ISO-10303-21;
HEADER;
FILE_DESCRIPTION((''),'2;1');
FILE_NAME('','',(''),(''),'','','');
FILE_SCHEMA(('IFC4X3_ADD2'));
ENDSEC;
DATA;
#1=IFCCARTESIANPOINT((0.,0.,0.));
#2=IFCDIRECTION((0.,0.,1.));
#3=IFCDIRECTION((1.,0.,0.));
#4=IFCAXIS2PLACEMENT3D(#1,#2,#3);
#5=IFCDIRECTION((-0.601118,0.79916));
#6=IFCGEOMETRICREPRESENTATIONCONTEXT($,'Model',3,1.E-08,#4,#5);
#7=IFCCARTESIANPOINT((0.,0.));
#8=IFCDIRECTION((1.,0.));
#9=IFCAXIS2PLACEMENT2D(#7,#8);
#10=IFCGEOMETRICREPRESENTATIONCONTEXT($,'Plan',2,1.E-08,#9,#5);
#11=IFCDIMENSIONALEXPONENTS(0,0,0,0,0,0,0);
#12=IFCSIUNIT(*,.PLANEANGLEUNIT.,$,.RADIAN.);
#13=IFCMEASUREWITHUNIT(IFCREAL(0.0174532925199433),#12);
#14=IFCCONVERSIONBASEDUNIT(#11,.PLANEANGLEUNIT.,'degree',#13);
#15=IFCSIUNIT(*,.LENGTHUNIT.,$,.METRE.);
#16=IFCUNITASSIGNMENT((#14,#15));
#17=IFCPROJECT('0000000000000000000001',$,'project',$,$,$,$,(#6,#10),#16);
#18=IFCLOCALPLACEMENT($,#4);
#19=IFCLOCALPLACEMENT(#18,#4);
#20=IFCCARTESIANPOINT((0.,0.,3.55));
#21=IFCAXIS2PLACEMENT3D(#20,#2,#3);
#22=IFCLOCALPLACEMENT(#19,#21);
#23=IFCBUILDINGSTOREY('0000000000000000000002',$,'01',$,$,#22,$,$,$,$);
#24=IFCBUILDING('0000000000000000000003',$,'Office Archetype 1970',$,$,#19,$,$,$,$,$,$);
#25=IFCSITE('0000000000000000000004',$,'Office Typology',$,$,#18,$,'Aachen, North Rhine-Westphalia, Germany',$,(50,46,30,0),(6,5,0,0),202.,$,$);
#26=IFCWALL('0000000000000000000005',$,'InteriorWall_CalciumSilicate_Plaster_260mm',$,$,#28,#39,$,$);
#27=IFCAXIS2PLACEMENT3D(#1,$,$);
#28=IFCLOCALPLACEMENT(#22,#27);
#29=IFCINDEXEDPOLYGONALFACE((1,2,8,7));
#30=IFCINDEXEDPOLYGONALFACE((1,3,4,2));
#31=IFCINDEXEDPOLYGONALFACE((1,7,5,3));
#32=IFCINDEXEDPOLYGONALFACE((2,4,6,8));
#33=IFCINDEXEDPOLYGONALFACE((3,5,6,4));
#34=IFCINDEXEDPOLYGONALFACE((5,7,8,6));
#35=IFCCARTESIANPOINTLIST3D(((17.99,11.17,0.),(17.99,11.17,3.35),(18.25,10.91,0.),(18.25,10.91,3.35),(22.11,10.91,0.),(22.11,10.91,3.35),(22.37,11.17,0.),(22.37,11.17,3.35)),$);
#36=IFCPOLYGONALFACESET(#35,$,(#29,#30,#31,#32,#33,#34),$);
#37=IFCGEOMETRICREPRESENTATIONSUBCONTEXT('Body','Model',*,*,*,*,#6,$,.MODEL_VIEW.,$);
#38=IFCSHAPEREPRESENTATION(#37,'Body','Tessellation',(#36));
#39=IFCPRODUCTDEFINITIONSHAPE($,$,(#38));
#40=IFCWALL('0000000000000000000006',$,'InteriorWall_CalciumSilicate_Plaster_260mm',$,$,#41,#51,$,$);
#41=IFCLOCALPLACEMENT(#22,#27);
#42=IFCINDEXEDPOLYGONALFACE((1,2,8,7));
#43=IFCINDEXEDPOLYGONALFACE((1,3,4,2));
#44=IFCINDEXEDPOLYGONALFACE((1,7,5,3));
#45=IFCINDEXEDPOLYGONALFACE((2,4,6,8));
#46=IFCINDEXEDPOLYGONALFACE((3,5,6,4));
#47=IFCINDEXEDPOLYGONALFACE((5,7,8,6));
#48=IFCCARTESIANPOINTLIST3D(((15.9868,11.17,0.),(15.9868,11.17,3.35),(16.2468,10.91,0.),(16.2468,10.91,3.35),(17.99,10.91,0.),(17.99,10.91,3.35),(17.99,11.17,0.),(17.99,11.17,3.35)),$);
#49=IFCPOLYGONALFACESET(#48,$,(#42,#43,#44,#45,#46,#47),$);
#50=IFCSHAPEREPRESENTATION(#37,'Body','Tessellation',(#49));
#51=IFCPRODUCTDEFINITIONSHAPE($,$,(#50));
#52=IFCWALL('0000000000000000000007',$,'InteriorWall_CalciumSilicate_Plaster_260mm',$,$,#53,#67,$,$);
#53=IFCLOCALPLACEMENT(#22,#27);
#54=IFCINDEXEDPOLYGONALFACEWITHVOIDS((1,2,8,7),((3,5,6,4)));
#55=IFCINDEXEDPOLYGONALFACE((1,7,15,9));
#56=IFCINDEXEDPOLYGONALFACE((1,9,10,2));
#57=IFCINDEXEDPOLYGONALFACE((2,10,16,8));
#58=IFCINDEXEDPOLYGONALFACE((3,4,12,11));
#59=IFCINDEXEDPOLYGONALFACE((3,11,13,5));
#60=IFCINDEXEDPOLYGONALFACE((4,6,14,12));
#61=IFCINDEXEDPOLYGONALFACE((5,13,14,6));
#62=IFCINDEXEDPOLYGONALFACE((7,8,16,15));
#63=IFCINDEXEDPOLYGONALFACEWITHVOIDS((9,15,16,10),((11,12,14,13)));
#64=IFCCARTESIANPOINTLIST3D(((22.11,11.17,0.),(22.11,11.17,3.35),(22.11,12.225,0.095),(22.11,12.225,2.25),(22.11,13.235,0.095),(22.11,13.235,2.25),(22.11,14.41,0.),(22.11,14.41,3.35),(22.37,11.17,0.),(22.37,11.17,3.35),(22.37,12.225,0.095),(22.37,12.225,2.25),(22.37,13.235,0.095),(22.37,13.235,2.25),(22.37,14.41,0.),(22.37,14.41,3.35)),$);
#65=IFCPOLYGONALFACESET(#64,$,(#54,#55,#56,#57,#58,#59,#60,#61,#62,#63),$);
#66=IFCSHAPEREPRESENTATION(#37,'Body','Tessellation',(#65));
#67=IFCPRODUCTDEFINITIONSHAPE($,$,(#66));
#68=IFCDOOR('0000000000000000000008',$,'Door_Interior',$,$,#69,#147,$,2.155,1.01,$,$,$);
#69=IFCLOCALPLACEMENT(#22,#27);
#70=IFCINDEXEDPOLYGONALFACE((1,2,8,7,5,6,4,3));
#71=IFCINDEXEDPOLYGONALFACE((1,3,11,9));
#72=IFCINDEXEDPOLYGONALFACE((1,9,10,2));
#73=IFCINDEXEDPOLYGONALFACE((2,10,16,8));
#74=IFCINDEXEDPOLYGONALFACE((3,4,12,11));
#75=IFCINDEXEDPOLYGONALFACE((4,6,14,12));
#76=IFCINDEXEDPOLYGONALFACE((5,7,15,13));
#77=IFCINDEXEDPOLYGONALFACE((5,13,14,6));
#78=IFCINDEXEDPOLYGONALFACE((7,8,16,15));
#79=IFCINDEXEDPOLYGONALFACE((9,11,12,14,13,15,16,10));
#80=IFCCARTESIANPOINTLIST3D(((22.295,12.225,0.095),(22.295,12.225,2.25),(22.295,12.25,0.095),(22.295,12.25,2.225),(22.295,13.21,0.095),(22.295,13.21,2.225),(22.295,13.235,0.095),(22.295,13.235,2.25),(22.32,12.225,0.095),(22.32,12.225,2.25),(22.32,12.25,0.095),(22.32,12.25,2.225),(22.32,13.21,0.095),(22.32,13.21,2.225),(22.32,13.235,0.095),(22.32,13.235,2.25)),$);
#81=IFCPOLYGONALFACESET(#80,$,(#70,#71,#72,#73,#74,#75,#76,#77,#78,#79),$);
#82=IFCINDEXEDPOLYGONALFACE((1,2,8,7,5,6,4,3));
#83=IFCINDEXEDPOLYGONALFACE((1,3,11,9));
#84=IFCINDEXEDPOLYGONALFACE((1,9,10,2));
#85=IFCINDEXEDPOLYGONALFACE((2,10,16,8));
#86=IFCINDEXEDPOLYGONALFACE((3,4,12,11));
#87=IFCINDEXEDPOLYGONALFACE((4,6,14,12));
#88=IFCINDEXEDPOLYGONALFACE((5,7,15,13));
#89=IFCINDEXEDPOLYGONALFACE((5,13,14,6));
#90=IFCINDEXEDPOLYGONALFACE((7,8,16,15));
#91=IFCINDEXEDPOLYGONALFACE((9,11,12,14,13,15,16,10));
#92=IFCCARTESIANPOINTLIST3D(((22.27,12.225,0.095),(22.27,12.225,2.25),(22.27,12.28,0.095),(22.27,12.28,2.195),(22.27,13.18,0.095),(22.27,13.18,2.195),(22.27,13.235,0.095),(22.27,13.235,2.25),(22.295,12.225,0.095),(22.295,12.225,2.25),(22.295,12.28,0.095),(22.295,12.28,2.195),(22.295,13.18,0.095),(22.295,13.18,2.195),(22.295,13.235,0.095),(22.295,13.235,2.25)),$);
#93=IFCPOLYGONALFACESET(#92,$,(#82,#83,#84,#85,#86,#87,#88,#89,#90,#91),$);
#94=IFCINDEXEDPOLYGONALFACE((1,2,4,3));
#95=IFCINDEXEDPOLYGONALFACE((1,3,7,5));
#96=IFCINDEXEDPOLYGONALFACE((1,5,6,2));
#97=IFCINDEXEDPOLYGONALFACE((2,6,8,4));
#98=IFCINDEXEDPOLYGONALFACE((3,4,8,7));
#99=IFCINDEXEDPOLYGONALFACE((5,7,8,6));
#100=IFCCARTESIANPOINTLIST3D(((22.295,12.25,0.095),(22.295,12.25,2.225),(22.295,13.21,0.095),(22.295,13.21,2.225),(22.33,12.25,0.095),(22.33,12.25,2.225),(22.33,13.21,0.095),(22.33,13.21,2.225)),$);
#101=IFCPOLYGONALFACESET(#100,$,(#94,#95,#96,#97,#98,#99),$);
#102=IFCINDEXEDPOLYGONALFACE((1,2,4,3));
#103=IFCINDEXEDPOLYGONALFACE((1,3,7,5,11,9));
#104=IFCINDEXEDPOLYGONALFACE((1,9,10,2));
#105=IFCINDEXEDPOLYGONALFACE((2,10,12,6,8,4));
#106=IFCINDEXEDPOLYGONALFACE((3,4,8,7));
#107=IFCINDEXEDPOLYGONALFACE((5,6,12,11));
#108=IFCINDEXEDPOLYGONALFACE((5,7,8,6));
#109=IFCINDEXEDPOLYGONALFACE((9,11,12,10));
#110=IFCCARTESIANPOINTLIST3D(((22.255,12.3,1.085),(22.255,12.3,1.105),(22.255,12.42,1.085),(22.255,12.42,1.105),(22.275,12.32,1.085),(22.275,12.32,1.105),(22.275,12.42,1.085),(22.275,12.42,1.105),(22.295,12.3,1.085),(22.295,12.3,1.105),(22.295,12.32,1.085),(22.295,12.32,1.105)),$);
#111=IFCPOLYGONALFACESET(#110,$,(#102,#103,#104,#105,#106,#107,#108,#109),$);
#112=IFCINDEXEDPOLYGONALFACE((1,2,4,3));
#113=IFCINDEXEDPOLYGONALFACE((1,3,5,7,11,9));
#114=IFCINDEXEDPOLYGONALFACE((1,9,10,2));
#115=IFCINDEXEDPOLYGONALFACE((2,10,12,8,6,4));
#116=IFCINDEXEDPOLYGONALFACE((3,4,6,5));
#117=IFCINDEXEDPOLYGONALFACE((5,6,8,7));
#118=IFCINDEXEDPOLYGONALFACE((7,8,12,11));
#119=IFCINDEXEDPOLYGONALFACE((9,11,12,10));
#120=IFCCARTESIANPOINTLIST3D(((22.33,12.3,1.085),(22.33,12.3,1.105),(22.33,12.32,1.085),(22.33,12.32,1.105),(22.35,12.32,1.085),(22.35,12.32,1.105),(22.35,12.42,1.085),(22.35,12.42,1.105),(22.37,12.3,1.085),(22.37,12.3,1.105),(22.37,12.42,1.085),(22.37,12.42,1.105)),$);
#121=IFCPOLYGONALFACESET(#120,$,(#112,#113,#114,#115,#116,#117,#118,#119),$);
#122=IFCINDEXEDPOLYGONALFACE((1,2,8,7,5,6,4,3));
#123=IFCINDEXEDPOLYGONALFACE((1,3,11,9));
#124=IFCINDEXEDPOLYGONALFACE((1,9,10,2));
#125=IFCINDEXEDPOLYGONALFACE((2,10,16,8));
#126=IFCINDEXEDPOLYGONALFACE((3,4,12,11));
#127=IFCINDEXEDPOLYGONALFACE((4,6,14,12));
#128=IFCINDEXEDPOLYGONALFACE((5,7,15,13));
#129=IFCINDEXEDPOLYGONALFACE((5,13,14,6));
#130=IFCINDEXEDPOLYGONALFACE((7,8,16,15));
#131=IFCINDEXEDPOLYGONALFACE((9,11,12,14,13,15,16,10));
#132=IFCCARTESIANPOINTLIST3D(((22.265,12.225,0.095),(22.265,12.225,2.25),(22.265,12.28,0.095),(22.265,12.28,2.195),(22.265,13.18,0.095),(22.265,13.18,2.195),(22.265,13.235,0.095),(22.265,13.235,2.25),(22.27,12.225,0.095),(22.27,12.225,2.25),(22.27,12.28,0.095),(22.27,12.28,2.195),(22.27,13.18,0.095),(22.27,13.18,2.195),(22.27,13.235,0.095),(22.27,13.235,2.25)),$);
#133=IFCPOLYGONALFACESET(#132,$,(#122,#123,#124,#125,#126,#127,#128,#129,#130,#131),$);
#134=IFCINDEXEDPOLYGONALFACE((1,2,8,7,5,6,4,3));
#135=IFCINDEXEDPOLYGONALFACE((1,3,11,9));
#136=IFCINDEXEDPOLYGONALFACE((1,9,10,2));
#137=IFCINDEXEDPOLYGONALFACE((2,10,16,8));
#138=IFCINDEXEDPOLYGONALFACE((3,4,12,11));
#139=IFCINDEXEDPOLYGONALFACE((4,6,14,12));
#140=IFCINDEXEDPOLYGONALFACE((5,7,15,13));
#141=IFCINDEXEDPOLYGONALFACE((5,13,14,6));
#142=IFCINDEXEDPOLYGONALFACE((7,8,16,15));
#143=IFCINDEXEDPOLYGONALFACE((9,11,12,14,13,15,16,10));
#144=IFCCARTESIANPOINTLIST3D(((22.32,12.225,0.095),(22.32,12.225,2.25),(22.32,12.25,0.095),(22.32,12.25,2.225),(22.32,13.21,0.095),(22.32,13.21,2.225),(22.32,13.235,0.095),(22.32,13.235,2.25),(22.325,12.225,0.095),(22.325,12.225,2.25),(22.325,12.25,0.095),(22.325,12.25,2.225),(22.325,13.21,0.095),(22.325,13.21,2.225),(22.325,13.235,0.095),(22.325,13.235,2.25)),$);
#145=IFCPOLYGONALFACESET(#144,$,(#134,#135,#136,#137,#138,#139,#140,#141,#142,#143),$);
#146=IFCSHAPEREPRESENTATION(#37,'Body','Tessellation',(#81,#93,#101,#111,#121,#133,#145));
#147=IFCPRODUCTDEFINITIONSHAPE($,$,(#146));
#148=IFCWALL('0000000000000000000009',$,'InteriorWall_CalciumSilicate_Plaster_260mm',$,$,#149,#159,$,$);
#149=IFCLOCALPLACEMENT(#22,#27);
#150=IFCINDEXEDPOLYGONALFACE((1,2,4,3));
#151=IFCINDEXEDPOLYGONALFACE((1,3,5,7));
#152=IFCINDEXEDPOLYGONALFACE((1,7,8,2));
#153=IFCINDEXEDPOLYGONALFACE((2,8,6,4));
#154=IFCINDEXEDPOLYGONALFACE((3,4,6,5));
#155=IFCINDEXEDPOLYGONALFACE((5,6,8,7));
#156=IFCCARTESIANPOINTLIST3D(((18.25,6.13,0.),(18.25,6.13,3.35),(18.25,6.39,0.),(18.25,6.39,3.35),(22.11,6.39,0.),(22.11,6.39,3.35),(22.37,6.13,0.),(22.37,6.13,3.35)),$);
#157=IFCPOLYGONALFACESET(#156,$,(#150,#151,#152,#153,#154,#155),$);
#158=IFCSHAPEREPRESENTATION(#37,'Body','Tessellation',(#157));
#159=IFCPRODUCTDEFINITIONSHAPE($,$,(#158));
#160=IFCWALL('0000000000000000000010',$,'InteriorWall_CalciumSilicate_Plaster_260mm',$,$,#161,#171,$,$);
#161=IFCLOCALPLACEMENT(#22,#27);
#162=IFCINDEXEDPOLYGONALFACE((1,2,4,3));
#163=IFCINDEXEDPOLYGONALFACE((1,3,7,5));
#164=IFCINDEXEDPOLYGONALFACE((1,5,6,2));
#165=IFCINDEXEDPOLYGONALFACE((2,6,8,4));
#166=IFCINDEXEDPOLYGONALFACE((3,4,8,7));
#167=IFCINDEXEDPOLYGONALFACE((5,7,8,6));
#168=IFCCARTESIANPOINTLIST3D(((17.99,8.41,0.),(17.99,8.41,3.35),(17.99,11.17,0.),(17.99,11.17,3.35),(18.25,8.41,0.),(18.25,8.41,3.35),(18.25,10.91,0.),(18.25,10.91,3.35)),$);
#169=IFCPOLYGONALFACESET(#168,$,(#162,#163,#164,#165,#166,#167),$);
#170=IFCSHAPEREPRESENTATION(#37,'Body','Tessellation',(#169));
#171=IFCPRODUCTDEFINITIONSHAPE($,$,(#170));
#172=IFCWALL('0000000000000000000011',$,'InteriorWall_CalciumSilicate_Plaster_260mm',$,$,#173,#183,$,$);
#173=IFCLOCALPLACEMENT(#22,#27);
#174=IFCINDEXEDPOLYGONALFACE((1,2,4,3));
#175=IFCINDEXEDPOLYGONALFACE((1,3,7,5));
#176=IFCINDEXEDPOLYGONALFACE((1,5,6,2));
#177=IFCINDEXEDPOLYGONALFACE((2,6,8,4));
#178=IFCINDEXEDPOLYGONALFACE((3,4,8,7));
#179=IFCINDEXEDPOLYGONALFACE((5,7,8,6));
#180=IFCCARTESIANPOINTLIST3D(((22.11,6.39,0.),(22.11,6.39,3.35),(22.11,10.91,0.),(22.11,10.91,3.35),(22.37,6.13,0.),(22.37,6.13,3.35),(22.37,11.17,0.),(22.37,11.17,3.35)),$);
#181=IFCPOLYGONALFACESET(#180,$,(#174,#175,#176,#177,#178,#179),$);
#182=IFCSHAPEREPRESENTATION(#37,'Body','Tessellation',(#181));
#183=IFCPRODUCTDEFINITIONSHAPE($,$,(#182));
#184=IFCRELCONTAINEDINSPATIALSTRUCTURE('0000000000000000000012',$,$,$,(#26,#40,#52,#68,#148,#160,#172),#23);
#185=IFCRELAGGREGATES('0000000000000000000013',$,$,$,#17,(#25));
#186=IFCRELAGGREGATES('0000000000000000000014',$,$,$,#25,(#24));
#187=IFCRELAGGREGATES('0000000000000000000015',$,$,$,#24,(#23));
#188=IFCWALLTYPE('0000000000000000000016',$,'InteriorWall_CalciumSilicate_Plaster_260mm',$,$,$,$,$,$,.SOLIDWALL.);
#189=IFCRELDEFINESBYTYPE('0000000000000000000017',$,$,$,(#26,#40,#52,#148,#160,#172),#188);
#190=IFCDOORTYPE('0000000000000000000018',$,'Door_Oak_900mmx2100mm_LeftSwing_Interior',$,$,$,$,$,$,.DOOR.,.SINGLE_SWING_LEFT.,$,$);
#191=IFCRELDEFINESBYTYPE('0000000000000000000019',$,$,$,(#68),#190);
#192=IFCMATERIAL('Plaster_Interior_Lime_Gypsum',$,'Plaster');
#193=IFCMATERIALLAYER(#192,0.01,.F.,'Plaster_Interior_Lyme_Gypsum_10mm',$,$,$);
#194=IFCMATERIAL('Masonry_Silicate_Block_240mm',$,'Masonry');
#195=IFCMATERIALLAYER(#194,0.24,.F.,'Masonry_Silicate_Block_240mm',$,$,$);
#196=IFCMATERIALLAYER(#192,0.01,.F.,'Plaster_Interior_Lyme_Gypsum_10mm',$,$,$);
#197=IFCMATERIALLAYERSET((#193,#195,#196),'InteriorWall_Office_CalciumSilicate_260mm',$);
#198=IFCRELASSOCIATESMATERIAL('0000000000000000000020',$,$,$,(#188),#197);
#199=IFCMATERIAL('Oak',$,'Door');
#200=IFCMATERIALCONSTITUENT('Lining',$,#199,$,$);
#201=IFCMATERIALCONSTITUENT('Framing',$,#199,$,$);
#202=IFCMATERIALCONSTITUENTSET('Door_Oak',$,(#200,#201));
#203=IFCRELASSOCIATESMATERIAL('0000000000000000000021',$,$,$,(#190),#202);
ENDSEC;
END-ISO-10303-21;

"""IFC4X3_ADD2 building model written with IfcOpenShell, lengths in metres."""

from ifc_helpers import new_model, entity, si_unit, converted_unit, direction, frame, origin_with_axes, origin_2d_with_axis, place, context, subcontext, project, spatial, line, indexed_curve, outline, extrude, source, transform, mapped, material, layer, layer_set, constituent, constituent_set, type_object, type_shapes, element, fill, save


model = new_model("IFC4X3_ADD2")

# Units and contexts
model_context = context("Model", 3, precision=1e-08, world=origin_with_axes(), true_north=direction((-0.601118, 0.79916)))
plan_context = context("Plan", 2, precision=1e-08, world=origin_2d_with_axis(), true_north=direction((-0.601118, 0.79916)))
body_context = subcontext(model_context, "Body", "Model", "MODEL_VIEW")
ifc_project = project(units=[converted_unit("PLANEANGLEUNIT", "degree", entity("IfcReal", 0.0174532925199433), si_unit("PLANEANGLEUNIT", "RADIAN"), dimensions=[0, 0, 0, 0, 0, 0, 0]), si_unit("LENGTHUNIT", "METRE")], contexts=[model_context, plan_context])

# Site, building, storey
site_placement = place(None, origin_with_axes())
site = spatial("IfcSite", under=ifc_project, at=site_placement, Name="Office Typology", LongName="Aachen, North Rhine-Westphalia, Germany", RefLatitude=(50, 46, 30, 0), RefLongitude=(6, 5, 0, 0), RefElevation=202.0)
building_placement = place(site_placement, origin_with_axes())
building = spatial("IfcBuilding", under=site, at=building_placement, Name="Office Archetype 1970")
storey_placement = place(building_placement, frame((0.0, 0.0, 3.55), z_axis=(0.0, 0.0, 1.0), x_axis=(1.0, 0.0, 0.0)))
storey = spatial("IfcBuildingStorey", under=building, at=storey_placement, Name="01")

# Shared definitions
ifc_material_1 = material(Name="Plaster_Interior_Lime_Gypsum", Category="Plaster")
ifc_layer_1 = layer(ifc_material_1, 0.01, ventilated=False, Name="Plaster_Interior_Lyme_Gypsum_10mm")
ifc_material_2 = material(Name="Masonry_Silicate_Block_240mm", Category="Masonry")
ifc_layer_2 = layer(ifc_material_2, 0.24, ventilated=False, Name="Masonry_Silicate_Block_240mm")
ifc_layer_3 = layer(ifc_material_1, 0.01, ventilated=False, Name="Plaster_Interior_Lyme_Gypsum_10mm")
ifc_layer_set_1 = layer_set([ifc_layer_1, ifc_layer_2, ifc_layer_3], Name="InteriorWall_Office_CalciumSilicate_260mm")
wall_type_1 = type_object("IfcWallType", Name="InteriorWall_CalciumSilicate_Plaster_260mm", PredefinedType="SOLIDWALL", material=ifc_layer_set_1)
ifc_material_3 = material(Name="Oak", Category="Door")

# Walls
wall_1_placement = place(storey_placement, frame((22.37, 11.17, 0.0), z_axis=(0.0, 0.0, 1.0), x_axis=(-1.0, 0.0, 0.0)))
element("IfcWall", 1, at=wall_1_placement, inside=storey, type_object=wall_type_1, Name="InteriorWall_CalciumSilicate_Plaster_260mm", context=body_context, shape_type="SweptSolid", body=[
    extrude(outline(indexed_curve([(0.0, 0.0), (0.26, 0.26), (4.12, 0.26), (4.38, 0.0)], segments=[line(1, 2, 3, 4, 1)])), origin_with_axes(), (0.0, 0.0, 1.0), 3.35),
])
wall_2_placement = place(storey_placement, frame((17.99, 11.17, 0.0), z_axis=(0.0, 0.0, 1.0), x_axis=(-1.0, 0.0, 0.0)))
element("IfcWall", 2, at=wall_2_placement, inside=storey, type_object=wall_type_1, Name="InteriorWall_CalciumSilicate_Plaster_260mm", context=body_context, shape_type="SweptSolid", body=[
    extrude(outline(indexed_curve([(0.0, 0.0), (0.0, 0.26), (1.7432, 0.26), (2.0032, 0.0)], segments=[line(1, 2, 3, 4, 1)])), origin_with_axes(), (0.0, 0.0, 1.0), 3.35),
])

# Wall, opening, door
wall_3_placement = place(storey_placement, frame((22.37, 11.17, 0.0), z_axis=(0.0, 0.0, 1.0), x_axis=(0.0, 1.0, 0.0)))
wall_3 = element("IfcWall", 3, at=wall_3_placement, inside=storey, type_object=wall_type_1, Name="InteriorWall_CalciumSilicate_Plaster_260mm", context=body_context, shape_type="SweptSolid", body=[
    extrude(outline(indexed_curve([(0.0, 0.0), (0.0, 0.26), (3.24, 0.26), (3.24, 0.0)], segments=[line(1, 2, 3, 4, 1)])), origin_with_axes(), (0.0, 0.0, 1.0), 3.35),
])
shared_shape_1 = source(origin_with_axes(), body_context, "Body", "SweptSolid", [
    extrude(outline(indexed_curve([(0.0, 0.0), (1.01, 0.0), (1.01, 2.155), (0.0, 2.155), (0.0, 0.0)])), frame((0.0, -0.16, 0.0), z_axis=(0.0, -1.0, 0.0), x_axis=(1.0, 0.0, 0.0)), (0.0, 0.0, -1.0), 0.261),
])
opening_1_placement = place(wall_3_placement, frame((2.065, 0.1, 0.095), z_axis=(0.0, 0.0, 1.0), x_axis=(-1.0, 0.0, 0.0)))
opening_1 = element("IfcOpeningElement", 4, at=opening_1_placement, cuts=wall_3, PredefinedType="OPENING", context=body_context, shape_type="MappedRepresentation", body=[
    mapped(shared_shape_1, transform((0.0, 0.0, 0.0), x_axis=(1.0, 0.0, 0.0), y_axis=(0.0, 1.0, 0.0), z_axis=(0.0, 0.0, 1.0), scale=1.0)),
])
ifc_constituent_1 = constituent(ifc_material_3, Name="Lining")
ifc_constituent_2 = constituent(ifc_material_3, Name="Framing")
ifc_constituent_set_1 = constituent_set(constituents=[ifc_constituent_1, ifc_constituent_2], Name="Door_Oak")
door_type_1 = type_object("IfcDoorType", Name="Door_Oak_900mmx2100mm_LeftSwing_Interior", OperationType="SINGLE_SWING_LEFT", PredefinedType="DOOR", material=ifc_constituent_set_1)
shared_shape_2 = source(origin_with_axes(), body_context, "Body", "SweptSolid", [
    extrude(outline(indexed_curve([(0.0, 0.0), (0.0, 2.155), (1.01, 2.155), (1.01, 0.0), (0.985, 0.0), (0.985, 2.13), (0.025, 2.13), (0.025, 0.0)], segments=[line(1, 2, 3, 4, 5, 6, 7, 8, 1)])), frame((0.0, 0.025, 0.0), z_axis=(0.0, -1.0, 0.0), x_axis=(1.0, 0.0, 0.0)), (0.0, 0.0, -1.0), 0.025),
    extrude(outline(indexed_curve([(0.0, 0.0), (0.0, 2.155), (1.01, 2.155), (1.01, 0.0), (0.955, 0.0), (0.955, 2.1), (0.055, 2.1), (0.055, 0.0)], segments=[line(1, 2, 3, 4, 5, 6, 7, 8, 1)])), frame((0.0, 0.0, 0.0), z_axis=(0.0, -1.0, 0.0), x_axis=(1.0, 0.0, 0.0)), (0.0, 0.0, -1.0), 0.025),
    extrude(outline(indexed_curve([(0.0, 0.0), (0.96, 0.0), (0.96, 0.035), (0.0, 0.035)], segments=[line(1, 2, 3, 4, 1)])), frame((0.025, 0.025, 0.0), z_axis=(0.0, 0.0, 1.0), x_axis=(1.0, 0.0, 0.0)), (0.0, 0.0, 1.0), 2.13),
    extrude(outline(indexed_curve([(0.0, 0.0), (0.0, -0.04), (-0.12, -0.04), (-0.12, -0.02), (-0.02, -0.02), (-0.02, 0.0)], segments=[line(1, 2, 3, 4, 5, 6, 1)])), frame((0.935, 0.025, 0.99), z_axis=(0.0, 0.0, 1.0), x_axis=(1.0, 0.0, 0.0)), (0.0, 0.0, 1.0), 0.02),
    extrude(outline(indexed_curve([(0.0, 0.0), (0.0, 0.04), (-0.12, 0.04), (-0.12, 0.02), (-0.02, 0.02), (-0.02, 0.0)], segments=[line(1, 2, 3, 4, 5, 6, 1)])), frame((0.935, 0.06, 0.99), z_axis=(0.0, 0.0, 1.0), x_axis=(1.0, 0.0, 0.0)), (0.0, 0.0, 1.0), 0.02),
    extrude(outline(indexed_curve([(0.0, 0.0), (0.0, 2.155), (1.01, 2.155), (1.01, 0.0), (0.955, 0.0), (0.955, 2.1), (0.055, 2.1), (0.055, 0.0)], segments=[line(1, 2, 3, 4, 5, 6, 7, 8, 1)])), frame((0.0, -0.005, 0.0), z_axis=(0.0, -1.0, 0.0), x_axis=(1.0, 0.0, 0.0)), (0.0, 0.0, -1.0), 0.005),
    extrude(outline(indexed_curve([(0.0, 0.0), (0.0, 2.155), (1.01, 2.155), (1.01, 0.0), (0.985, 0.0), (0.985, 2.13), (0.025, 2.13), (0.025, 0.0)], segments=[line(1, 2, 3, 4, 5, 6, 7, 8, 1)])), frame((0.0, 0.05, 0.0), z_axis=(0.0, -1.0, 0.0), x_axis=(1.0, 0.0, 0.0)), (0.0, 0.0, -1.0), 0.005),
])
type_shapes(door_type_1, [shared_shape_2])
door_1_placement = place(opening_1_placement, origin_with_axes())
door_1 = element("IfcDoor", 5, at=door_1_placement, inside=storey, type_object=door_type_1, Name="Door_Interior", OverallHeight=2.155, OverallWidth=1.01, context=body_context, shape_type="MappedRepresentation", body=[
    mapped(shared_shape_2, transform((0.0, 0.0, 0.0), x_axis=(1.0, 0.0, 0.0), y_axis=(0.0, 1.0, 0.0), z_axis=(0.0, 0.0, 1.0), scale=1.0)),
])
fill(opening_1, door_1)

# Walls
wall_4_placement = place(storey_placement, frame((18.25, 6.13, 0.0), z_axis=(0.0, 0.0, 1.0), x_axis=(1.0, 0.0, 0.0)))
element("IfcWall", 6, at=wall_4_placement, inside=storey, type_object=wall_type_1, Name="InteriorWall_CalciumSilicate_Plaster_260mm", context=body_context, shape_type="SweptSolid", body=[
    extrude(outline(indexed_curve([(0.0, 0.0), (0.0, 0.26), (3.86, 0.26), (4.12, 0.0)], segments=[line(1, 2, 3, 4, 1)])), origin_with_axes(), (0.0, 0.0, 1.0), 3.35),
])
wall_5_placement = place(storey_placement, frame((17.99, 11.17, 0.0), z_axis=(0.0, 0.0, 1.0), x_axis=(0.0, -1.0, 0.0)))
element("IfcWall", 7, at=wall_5_placement, inside=storey, type_object=wall_type_1, Name="InteriorWall_CalciumSilicate_Plaster_260mm", context=body_context, shape_type="SweptSolid", body=[
    extrude(outline(indexed_curve([(0.0, 0.0), (0.26, 0.26), (2.76, 0.26), (2.76, 0.0)], segments=[line(1, 2, 3, 4, 1)])), origin_with_axes(), (0.0, 0.0, 1.0), 3.35),
])
wall_6_placement = place(storey_placement, frame((22.37, 6.13, 0.0), z_axis=(0.0, 0.0, 1.0), x_axis=(0.0, 1.0, 0.0)))
element("IfcWall", 8, at=wall_6_placement, inside=storey, type_object=wall_type_1, Name="InteriorWall_CalciumSilicate_Plaster_260mm", context=body_context, shape_type="SweptSolid", body=[
    extrude(outline(indexed_curve([(0.0, 0.0), (0.26, 0.26), (4.78, 0.26), (5.04, 0.0)], segments=[line(1, 2, 3, 4, 1)])), origin_with_axes(), (0.0, 0.0, 1.0), 3.35),
])

save(model, "model.ifc")
